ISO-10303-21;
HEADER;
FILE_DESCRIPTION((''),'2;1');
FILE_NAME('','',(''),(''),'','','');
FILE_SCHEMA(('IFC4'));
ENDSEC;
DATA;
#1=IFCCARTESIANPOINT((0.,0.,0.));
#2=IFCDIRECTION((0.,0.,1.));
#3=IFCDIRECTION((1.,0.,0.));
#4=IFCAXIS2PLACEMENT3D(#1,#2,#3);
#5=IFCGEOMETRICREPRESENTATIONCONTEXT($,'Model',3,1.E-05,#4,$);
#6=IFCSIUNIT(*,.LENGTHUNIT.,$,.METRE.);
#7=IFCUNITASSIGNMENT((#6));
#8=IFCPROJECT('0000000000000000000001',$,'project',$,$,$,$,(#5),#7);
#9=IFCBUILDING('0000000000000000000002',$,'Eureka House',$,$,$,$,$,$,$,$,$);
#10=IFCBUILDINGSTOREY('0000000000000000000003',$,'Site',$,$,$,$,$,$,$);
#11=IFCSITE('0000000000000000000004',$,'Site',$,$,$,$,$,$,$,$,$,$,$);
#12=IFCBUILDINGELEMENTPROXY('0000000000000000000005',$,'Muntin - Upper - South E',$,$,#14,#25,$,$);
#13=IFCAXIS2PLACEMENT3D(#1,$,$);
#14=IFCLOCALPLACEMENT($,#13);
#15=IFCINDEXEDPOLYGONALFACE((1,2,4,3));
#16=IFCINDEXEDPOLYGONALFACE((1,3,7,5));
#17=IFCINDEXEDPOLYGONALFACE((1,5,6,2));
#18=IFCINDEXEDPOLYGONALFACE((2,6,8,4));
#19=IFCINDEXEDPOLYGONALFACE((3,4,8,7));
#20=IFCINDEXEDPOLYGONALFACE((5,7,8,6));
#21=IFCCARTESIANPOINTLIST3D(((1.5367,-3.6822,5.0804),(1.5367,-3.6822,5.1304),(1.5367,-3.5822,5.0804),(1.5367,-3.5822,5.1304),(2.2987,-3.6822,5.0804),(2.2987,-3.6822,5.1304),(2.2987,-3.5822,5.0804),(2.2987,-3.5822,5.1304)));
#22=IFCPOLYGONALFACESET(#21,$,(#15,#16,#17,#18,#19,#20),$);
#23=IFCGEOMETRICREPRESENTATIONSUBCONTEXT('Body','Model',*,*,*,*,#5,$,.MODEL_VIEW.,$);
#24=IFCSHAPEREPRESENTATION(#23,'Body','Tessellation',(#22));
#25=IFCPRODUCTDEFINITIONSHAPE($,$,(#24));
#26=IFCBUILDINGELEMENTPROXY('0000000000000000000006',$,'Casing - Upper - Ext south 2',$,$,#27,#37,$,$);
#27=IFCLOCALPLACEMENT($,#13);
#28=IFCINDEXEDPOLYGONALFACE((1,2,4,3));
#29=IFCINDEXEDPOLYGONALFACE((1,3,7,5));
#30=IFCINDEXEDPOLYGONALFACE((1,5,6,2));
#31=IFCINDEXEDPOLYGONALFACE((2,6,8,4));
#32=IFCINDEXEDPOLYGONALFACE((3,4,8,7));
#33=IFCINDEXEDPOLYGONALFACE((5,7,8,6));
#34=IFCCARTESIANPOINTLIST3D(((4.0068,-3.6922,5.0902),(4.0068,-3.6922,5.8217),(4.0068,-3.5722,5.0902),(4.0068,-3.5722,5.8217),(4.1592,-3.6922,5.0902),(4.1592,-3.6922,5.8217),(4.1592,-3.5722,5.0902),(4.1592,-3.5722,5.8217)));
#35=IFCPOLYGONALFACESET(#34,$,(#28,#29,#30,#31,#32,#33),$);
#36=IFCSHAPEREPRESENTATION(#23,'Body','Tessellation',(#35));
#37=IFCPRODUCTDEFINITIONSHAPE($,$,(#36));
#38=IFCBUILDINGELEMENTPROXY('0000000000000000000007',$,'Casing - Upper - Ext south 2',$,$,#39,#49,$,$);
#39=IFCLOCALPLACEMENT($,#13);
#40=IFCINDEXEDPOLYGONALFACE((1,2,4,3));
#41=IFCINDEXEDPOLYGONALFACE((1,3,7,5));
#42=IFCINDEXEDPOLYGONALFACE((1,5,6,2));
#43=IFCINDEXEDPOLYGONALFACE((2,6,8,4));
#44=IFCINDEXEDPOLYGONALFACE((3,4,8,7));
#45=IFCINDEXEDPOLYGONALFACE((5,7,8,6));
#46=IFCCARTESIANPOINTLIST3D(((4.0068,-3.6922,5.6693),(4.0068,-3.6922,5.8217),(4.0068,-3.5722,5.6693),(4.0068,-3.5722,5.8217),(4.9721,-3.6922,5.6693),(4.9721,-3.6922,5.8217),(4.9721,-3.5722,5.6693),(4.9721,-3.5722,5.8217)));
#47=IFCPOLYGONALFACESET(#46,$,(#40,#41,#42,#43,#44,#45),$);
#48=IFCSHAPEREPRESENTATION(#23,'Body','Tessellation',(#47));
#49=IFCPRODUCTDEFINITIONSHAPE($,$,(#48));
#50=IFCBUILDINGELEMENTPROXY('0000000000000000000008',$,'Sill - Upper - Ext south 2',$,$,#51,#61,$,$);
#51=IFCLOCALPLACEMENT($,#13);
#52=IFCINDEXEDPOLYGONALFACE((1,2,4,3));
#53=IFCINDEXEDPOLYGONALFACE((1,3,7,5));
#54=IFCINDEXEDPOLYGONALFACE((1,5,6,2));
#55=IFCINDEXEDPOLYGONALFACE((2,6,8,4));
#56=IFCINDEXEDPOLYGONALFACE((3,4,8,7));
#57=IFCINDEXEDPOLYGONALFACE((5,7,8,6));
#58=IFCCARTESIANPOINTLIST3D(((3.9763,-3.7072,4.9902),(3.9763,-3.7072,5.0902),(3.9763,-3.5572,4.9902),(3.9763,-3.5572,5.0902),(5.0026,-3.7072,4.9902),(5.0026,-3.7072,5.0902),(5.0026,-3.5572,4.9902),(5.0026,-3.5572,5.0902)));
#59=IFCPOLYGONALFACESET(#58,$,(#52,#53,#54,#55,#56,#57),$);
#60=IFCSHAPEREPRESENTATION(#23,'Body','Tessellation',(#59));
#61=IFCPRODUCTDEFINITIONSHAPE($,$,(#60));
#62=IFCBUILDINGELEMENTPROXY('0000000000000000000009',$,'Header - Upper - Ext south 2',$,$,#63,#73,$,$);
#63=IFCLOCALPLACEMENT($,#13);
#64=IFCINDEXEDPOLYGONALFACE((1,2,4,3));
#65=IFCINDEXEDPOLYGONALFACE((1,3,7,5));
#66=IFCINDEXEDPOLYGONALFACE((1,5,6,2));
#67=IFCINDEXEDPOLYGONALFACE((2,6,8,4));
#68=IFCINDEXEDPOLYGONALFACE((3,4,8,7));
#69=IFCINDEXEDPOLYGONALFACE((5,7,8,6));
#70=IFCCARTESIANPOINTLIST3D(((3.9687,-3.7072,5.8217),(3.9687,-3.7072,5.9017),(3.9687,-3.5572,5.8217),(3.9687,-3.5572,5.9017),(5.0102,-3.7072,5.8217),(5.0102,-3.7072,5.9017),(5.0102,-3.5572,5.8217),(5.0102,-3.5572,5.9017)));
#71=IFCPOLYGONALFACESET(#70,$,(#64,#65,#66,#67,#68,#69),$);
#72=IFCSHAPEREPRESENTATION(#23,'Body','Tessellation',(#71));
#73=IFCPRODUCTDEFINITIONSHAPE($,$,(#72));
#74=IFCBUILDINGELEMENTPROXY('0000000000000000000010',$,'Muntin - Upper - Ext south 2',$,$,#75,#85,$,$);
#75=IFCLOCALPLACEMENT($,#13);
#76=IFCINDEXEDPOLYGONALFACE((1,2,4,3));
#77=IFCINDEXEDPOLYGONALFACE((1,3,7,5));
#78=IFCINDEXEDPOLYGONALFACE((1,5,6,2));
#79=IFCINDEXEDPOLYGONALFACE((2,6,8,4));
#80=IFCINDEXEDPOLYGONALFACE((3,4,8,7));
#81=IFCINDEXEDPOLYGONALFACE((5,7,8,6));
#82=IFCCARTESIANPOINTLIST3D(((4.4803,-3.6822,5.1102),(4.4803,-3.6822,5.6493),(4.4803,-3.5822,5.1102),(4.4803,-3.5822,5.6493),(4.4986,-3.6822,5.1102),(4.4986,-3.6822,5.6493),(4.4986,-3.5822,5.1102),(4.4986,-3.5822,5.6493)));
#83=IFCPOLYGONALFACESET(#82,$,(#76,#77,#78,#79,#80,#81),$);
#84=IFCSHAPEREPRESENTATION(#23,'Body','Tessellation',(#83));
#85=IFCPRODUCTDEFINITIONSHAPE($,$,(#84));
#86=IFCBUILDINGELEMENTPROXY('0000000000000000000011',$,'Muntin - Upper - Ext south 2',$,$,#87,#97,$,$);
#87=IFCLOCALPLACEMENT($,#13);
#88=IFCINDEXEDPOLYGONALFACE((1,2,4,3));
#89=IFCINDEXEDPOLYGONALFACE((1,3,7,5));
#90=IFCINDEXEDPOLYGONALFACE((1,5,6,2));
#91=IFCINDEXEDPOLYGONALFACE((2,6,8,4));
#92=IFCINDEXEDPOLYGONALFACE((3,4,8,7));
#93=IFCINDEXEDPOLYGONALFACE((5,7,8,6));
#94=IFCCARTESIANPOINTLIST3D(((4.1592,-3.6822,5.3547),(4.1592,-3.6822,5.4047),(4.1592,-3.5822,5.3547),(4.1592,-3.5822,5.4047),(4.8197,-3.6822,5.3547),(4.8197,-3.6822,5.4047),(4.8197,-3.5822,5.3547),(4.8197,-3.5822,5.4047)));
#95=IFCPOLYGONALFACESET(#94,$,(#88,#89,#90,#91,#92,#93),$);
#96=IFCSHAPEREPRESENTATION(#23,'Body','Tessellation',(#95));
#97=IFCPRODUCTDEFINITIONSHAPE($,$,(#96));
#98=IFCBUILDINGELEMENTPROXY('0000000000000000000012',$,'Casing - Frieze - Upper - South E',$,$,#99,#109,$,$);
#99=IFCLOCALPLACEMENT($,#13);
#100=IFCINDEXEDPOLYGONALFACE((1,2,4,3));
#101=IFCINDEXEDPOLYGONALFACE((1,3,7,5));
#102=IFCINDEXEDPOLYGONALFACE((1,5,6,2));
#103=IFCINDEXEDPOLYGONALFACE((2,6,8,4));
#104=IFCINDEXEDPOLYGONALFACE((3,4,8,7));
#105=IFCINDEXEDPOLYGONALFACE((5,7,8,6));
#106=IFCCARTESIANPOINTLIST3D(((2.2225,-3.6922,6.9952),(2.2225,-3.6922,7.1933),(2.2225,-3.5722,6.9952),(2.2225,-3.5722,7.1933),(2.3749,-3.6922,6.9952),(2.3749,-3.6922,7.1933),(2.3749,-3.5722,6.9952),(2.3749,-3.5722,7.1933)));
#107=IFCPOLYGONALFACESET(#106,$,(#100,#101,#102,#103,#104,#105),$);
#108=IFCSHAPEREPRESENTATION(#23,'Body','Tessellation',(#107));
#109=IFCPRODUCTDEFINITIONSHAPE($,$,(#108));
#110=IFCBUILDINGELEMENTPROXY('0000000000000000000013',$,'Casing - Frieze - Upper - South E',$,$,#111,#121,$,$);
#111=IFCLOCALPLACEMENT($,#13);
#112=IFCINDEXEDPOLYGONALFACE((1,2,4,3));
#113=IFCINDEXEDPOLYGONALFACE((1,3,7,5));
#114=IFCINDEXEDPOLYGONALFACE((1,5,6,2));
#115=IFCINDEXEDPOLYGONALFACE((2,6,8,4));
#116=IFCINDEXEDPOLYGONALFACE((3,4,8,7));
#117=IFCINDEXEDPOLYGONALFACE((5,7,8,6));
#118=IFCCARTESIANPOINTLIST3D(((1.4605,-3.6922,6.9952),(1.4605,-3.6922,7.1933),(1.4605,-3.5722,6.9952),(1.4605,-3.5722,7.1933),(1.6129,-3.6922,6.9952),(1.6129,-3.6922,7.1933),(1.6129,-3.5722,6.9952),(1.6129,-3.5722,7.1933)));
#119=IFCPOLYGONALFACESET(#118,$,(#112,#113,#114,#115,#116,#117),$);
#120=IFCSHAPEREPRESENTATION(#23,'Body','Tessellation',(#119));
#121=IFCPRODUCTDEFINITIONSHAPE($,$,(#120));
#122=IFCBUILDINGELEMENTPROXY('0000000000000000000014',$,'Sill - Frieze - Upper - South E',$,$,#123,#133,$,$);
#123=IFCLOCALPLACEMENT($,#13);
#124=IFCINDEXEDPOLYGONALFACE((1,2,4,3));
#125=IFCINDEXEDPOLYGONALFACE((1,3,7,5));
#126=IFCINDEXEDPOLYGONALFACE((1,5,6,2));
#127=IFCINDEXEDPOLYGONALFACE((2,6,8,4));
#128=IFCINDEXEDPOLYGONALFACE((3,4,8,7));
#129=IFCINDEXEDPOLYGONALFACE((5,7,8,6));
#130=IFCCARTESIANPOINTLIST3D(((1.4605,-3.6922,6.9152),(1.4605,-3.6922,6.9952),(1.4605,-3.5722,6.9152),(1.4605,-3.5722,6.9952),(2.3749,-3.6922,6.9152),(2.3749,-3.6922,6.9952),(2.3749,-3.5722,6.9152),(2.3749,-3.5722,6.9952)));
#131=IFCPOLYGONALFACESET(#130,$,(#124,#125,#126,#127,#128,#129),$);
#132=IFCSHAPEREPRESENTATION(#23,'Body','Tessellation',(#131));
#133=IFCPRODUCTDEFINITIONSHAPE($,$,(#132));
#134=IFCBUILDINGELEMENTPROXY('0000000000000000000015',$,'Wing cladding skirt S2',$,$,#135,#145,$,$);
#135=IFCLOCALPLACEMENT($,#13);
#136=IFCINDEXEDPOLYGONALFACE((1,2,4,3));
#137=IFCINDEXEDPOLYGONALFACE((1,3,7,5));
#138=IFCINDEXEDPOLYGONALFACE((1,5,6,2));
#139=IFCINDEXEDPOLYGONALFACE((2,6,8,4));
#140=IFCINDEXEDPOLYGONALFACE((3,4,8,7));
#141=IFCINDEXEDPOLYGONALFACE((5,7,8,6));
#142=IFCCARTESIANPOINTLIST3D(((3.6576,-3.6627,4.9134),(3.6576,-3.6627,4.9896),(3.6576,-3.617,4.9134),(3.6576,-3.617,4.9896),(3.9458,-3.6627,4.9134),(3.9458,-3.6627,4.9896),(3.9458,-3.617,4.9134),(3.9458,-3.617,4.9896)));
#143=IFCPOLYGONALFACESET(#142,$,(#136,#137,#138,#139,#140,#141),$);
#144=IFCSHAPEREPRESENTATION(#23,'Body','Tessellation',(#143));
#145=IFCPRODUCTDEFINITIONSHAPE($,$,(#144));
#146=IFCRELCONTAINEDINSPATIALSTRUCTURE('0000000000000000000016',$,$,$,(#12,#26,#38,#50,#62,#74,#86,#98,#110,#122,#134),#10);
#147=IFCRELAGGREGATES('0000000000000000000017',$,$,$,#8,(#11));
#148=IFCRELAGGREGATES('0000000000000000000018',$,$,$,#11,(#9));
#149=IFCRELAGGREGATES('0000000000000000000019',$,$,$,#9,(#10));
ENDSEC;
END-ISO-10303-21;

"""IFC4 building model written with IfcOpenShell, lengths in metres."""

from ifc_helpers import new_model, si_unit, frame, origin, origin_with_axes, origin_2d, place, context, subcontext, project, spatial, rectangle, extrude, element, save


model = new_model("IFC4")

# Units and contexts
model_context = context("Model", 3, precision=1e-05, world=origin_with_axes())
body_context = subcontext(model_context, "Body", "Model", "MODEL_VIEW")
ifc_project = project(units=[si_unit("LENGTHUNIT", "METRE")], contexts=[model_context])

# Site, building, storey
site = spatial("IfcSite", under=ifc_project, Name="Site")
building = spatial("IfcBuilding", under=site, Name="Eureka House")
storey = spatial("IfcBuildingStorey", under=building, Name="Site")

# Building element proxies
proxy_1_placement = place(None, frame((1.9177, -3.6322, 5.0804), z_axis=(0.0, 0.0, 1.0), x_axis=(1.0, 0.0, 0.0)))
element("IfcBuildingElementProxy", 1, at=proxy_1_placement, inside=storey, Name="Muntin - Upper - South E", context=body_context, shape_type="SweptSolid", body=[
    extrude(rectangle(XDim=0.762, YDim=0.1, at=origin_2d()), origin(), (0.0, 0.0, 1.0), 0.05),
])
proxy_2_placement = place(None, frame((4.083, -3.6322, 5.0902), z_axis=(0.0, 0.0, 1.0), x_axis=(1.0, 0.0, 0.0)))
element("IfcBuildingElementProxy", 2, at=proxy_2_placement, inside=storey, Name="Casing - Upper - Ext south 2", context=body_context, shape_type="SweptSolid", body=[
    extrude(rectangle(XDim=0.1524, YDim=0.12, at=origin_2d()), origin(), (0.0, 0.0, 1.0), 0.7315),
])
proxy_3_placement = place(None, frame((4.4894, -3.6322, 5.6693), z_axis=(0.0, 0.0, 1.0), x_axis=(1.0, 0.0, 0.0)))
element("IfcBuildingElementProxy", 3, at=proxy_3_placement, inside=storey, Name="Casing - Upper - Ext south 2", context=body_context, shape_type="SweptSolid", body=[
    extrude(rectangle(XDim=0.9653, YDim=0.12, at=origin_2d()), origin(), (0.0, 0.0, 1.0), 0.1524),
])
proxy_4_placement = place(None, frame((4.4894, -3.6322, 4.9902), z_axis=(0.0, 0.0, 1.0), x_axis=(1.0, 0.0, 0.0)))
element("IfcBuildingElementProxy", 4, at=proxy_4_placement, inside=storey, Name="Sill - Upper - Ext south 2", context=body_context, shape_type="SweptSolid", body=[
    extrude(rectangle(XDim=1.0263, YDim=0.15, at=origin_2d()), origin(), (0.0, 0.0, 1.0), 0.1),
])
proxy_5_placement = place(None, frame((4.4894, -3.6322, 5.8217), z_axis=(0.0, 0.0, 1.0), x_axis=(1.0, 0.0, 0.0)))
element("IfcBuildingElementProxy", 5, at=proxy_5_placement, inside=storey, Name="Header - Upper - Ext south 2", context=body_context, shape_type="SweptSolid", body=[
    extrude(rectangle(XDim=1.0415, YDim=0.15, at=origin_2d()), origin(), (0.0, 0.0, 1.0), 0.08),
])
proxy_6_placement = place(None, frame((4.4894, -3.6322, 5.1102), z_axis=(0.0, 0.0, 1.0), x_axis=(1.0, 0.0, 0.0)))
element("IfcBuildingElementProxy", 6, at=proxy_6_placement, inside=storey, Name="Muntin - Upper - Ext south 2", context=body_context, shape_type="SweptSolid", body=[
    extrude(rectangle(XDim=0.0183, YDim=0.1, at=origin_2d()), origin(), (0.0, 0.0, 1.0), 0.5391),
])
proxy_7_placement = place(None, frame((4.4894, -3.6322, 5.3547), z_axis=(0.0, 0.0, 1.0), x_axis=(1.0, 0.0, 0.0)))
element("IfcBuildingElementProxy", 7, at=proxy_7_placement, inside=storey, Name="Muntin - Upper - Ext south 2", context=body_context, shape_type="SweptSolid", body=[
    extrude(rectangle(XDim=0.6605, YDim=0.1, at=origin_2d()), origin(), (0.0, 0.0, 1.0), 0.05),
])
for number, where, z_axis, x_axis, name in (
    (8, (2.2987, -3.6322, 6.9952), (0.0, 0.0, 1.0), (1.0, 0.0, 0.0), "Casing - Frieze - Upper - South E"),
    (9, (1.5367, -3.6322, 6.9952), (0.0, 0.0, 1.0), (1.0, 0.0, 0.0), "Casing - Frieze - Upper - South E"),
):
    element("IfcBuildingElementProxy", number, at=place(None, frame(where, z_axis=z_axis, x_axis=x_axis)), inside=storey, Name=name, context=body_context, shape_type="SweptSolid", body=[
        extrude(rectangle(XDim=0.1524, YDim=0.12, at=origin_2d()), origin(), (0.0, 0.0, 1.0), 0.1981),
    ])
proxy_8_placement = place(None, frame((1.9177, -3.6322, 6.9152), z_axis=(0.0, 0.0, 1.0), x_axis=(1.0, 0.0, 0.0)))
element("IfcBuildingElementProxy", 10, at=proxy_8_placement, inside=storey, Name="Sill - Frieze - Upper - South E", context=body_context, shape_type="SweptSolid", body=[
    extrude(rectangle(XDim=0.9144, YDim=0.12, at=origin_2d()), origin(), (0.0, 0.0, 1.0), 0.08),
])
proxy_9_placement = place(None, frame((3.8017, -3.6398, 4.9134), z_axis=(0.0, 0.0, 1.0), x_axis=(1.0, 0.0, 0.0)))
element("IfcBuildingElementProxy", 11, at=proxy_9_placement, inside=storey, Name="Wing cladding skirt S2", context=body_context, shape_type="SweptSolid", body=[
    extrude(rectangle(XDim=0.2882, YDim=0.0457, at=origin_2d()), origin(), (0.0, 0.0, 1.0), 0.0762),
])

save(model, "model.ifc")
